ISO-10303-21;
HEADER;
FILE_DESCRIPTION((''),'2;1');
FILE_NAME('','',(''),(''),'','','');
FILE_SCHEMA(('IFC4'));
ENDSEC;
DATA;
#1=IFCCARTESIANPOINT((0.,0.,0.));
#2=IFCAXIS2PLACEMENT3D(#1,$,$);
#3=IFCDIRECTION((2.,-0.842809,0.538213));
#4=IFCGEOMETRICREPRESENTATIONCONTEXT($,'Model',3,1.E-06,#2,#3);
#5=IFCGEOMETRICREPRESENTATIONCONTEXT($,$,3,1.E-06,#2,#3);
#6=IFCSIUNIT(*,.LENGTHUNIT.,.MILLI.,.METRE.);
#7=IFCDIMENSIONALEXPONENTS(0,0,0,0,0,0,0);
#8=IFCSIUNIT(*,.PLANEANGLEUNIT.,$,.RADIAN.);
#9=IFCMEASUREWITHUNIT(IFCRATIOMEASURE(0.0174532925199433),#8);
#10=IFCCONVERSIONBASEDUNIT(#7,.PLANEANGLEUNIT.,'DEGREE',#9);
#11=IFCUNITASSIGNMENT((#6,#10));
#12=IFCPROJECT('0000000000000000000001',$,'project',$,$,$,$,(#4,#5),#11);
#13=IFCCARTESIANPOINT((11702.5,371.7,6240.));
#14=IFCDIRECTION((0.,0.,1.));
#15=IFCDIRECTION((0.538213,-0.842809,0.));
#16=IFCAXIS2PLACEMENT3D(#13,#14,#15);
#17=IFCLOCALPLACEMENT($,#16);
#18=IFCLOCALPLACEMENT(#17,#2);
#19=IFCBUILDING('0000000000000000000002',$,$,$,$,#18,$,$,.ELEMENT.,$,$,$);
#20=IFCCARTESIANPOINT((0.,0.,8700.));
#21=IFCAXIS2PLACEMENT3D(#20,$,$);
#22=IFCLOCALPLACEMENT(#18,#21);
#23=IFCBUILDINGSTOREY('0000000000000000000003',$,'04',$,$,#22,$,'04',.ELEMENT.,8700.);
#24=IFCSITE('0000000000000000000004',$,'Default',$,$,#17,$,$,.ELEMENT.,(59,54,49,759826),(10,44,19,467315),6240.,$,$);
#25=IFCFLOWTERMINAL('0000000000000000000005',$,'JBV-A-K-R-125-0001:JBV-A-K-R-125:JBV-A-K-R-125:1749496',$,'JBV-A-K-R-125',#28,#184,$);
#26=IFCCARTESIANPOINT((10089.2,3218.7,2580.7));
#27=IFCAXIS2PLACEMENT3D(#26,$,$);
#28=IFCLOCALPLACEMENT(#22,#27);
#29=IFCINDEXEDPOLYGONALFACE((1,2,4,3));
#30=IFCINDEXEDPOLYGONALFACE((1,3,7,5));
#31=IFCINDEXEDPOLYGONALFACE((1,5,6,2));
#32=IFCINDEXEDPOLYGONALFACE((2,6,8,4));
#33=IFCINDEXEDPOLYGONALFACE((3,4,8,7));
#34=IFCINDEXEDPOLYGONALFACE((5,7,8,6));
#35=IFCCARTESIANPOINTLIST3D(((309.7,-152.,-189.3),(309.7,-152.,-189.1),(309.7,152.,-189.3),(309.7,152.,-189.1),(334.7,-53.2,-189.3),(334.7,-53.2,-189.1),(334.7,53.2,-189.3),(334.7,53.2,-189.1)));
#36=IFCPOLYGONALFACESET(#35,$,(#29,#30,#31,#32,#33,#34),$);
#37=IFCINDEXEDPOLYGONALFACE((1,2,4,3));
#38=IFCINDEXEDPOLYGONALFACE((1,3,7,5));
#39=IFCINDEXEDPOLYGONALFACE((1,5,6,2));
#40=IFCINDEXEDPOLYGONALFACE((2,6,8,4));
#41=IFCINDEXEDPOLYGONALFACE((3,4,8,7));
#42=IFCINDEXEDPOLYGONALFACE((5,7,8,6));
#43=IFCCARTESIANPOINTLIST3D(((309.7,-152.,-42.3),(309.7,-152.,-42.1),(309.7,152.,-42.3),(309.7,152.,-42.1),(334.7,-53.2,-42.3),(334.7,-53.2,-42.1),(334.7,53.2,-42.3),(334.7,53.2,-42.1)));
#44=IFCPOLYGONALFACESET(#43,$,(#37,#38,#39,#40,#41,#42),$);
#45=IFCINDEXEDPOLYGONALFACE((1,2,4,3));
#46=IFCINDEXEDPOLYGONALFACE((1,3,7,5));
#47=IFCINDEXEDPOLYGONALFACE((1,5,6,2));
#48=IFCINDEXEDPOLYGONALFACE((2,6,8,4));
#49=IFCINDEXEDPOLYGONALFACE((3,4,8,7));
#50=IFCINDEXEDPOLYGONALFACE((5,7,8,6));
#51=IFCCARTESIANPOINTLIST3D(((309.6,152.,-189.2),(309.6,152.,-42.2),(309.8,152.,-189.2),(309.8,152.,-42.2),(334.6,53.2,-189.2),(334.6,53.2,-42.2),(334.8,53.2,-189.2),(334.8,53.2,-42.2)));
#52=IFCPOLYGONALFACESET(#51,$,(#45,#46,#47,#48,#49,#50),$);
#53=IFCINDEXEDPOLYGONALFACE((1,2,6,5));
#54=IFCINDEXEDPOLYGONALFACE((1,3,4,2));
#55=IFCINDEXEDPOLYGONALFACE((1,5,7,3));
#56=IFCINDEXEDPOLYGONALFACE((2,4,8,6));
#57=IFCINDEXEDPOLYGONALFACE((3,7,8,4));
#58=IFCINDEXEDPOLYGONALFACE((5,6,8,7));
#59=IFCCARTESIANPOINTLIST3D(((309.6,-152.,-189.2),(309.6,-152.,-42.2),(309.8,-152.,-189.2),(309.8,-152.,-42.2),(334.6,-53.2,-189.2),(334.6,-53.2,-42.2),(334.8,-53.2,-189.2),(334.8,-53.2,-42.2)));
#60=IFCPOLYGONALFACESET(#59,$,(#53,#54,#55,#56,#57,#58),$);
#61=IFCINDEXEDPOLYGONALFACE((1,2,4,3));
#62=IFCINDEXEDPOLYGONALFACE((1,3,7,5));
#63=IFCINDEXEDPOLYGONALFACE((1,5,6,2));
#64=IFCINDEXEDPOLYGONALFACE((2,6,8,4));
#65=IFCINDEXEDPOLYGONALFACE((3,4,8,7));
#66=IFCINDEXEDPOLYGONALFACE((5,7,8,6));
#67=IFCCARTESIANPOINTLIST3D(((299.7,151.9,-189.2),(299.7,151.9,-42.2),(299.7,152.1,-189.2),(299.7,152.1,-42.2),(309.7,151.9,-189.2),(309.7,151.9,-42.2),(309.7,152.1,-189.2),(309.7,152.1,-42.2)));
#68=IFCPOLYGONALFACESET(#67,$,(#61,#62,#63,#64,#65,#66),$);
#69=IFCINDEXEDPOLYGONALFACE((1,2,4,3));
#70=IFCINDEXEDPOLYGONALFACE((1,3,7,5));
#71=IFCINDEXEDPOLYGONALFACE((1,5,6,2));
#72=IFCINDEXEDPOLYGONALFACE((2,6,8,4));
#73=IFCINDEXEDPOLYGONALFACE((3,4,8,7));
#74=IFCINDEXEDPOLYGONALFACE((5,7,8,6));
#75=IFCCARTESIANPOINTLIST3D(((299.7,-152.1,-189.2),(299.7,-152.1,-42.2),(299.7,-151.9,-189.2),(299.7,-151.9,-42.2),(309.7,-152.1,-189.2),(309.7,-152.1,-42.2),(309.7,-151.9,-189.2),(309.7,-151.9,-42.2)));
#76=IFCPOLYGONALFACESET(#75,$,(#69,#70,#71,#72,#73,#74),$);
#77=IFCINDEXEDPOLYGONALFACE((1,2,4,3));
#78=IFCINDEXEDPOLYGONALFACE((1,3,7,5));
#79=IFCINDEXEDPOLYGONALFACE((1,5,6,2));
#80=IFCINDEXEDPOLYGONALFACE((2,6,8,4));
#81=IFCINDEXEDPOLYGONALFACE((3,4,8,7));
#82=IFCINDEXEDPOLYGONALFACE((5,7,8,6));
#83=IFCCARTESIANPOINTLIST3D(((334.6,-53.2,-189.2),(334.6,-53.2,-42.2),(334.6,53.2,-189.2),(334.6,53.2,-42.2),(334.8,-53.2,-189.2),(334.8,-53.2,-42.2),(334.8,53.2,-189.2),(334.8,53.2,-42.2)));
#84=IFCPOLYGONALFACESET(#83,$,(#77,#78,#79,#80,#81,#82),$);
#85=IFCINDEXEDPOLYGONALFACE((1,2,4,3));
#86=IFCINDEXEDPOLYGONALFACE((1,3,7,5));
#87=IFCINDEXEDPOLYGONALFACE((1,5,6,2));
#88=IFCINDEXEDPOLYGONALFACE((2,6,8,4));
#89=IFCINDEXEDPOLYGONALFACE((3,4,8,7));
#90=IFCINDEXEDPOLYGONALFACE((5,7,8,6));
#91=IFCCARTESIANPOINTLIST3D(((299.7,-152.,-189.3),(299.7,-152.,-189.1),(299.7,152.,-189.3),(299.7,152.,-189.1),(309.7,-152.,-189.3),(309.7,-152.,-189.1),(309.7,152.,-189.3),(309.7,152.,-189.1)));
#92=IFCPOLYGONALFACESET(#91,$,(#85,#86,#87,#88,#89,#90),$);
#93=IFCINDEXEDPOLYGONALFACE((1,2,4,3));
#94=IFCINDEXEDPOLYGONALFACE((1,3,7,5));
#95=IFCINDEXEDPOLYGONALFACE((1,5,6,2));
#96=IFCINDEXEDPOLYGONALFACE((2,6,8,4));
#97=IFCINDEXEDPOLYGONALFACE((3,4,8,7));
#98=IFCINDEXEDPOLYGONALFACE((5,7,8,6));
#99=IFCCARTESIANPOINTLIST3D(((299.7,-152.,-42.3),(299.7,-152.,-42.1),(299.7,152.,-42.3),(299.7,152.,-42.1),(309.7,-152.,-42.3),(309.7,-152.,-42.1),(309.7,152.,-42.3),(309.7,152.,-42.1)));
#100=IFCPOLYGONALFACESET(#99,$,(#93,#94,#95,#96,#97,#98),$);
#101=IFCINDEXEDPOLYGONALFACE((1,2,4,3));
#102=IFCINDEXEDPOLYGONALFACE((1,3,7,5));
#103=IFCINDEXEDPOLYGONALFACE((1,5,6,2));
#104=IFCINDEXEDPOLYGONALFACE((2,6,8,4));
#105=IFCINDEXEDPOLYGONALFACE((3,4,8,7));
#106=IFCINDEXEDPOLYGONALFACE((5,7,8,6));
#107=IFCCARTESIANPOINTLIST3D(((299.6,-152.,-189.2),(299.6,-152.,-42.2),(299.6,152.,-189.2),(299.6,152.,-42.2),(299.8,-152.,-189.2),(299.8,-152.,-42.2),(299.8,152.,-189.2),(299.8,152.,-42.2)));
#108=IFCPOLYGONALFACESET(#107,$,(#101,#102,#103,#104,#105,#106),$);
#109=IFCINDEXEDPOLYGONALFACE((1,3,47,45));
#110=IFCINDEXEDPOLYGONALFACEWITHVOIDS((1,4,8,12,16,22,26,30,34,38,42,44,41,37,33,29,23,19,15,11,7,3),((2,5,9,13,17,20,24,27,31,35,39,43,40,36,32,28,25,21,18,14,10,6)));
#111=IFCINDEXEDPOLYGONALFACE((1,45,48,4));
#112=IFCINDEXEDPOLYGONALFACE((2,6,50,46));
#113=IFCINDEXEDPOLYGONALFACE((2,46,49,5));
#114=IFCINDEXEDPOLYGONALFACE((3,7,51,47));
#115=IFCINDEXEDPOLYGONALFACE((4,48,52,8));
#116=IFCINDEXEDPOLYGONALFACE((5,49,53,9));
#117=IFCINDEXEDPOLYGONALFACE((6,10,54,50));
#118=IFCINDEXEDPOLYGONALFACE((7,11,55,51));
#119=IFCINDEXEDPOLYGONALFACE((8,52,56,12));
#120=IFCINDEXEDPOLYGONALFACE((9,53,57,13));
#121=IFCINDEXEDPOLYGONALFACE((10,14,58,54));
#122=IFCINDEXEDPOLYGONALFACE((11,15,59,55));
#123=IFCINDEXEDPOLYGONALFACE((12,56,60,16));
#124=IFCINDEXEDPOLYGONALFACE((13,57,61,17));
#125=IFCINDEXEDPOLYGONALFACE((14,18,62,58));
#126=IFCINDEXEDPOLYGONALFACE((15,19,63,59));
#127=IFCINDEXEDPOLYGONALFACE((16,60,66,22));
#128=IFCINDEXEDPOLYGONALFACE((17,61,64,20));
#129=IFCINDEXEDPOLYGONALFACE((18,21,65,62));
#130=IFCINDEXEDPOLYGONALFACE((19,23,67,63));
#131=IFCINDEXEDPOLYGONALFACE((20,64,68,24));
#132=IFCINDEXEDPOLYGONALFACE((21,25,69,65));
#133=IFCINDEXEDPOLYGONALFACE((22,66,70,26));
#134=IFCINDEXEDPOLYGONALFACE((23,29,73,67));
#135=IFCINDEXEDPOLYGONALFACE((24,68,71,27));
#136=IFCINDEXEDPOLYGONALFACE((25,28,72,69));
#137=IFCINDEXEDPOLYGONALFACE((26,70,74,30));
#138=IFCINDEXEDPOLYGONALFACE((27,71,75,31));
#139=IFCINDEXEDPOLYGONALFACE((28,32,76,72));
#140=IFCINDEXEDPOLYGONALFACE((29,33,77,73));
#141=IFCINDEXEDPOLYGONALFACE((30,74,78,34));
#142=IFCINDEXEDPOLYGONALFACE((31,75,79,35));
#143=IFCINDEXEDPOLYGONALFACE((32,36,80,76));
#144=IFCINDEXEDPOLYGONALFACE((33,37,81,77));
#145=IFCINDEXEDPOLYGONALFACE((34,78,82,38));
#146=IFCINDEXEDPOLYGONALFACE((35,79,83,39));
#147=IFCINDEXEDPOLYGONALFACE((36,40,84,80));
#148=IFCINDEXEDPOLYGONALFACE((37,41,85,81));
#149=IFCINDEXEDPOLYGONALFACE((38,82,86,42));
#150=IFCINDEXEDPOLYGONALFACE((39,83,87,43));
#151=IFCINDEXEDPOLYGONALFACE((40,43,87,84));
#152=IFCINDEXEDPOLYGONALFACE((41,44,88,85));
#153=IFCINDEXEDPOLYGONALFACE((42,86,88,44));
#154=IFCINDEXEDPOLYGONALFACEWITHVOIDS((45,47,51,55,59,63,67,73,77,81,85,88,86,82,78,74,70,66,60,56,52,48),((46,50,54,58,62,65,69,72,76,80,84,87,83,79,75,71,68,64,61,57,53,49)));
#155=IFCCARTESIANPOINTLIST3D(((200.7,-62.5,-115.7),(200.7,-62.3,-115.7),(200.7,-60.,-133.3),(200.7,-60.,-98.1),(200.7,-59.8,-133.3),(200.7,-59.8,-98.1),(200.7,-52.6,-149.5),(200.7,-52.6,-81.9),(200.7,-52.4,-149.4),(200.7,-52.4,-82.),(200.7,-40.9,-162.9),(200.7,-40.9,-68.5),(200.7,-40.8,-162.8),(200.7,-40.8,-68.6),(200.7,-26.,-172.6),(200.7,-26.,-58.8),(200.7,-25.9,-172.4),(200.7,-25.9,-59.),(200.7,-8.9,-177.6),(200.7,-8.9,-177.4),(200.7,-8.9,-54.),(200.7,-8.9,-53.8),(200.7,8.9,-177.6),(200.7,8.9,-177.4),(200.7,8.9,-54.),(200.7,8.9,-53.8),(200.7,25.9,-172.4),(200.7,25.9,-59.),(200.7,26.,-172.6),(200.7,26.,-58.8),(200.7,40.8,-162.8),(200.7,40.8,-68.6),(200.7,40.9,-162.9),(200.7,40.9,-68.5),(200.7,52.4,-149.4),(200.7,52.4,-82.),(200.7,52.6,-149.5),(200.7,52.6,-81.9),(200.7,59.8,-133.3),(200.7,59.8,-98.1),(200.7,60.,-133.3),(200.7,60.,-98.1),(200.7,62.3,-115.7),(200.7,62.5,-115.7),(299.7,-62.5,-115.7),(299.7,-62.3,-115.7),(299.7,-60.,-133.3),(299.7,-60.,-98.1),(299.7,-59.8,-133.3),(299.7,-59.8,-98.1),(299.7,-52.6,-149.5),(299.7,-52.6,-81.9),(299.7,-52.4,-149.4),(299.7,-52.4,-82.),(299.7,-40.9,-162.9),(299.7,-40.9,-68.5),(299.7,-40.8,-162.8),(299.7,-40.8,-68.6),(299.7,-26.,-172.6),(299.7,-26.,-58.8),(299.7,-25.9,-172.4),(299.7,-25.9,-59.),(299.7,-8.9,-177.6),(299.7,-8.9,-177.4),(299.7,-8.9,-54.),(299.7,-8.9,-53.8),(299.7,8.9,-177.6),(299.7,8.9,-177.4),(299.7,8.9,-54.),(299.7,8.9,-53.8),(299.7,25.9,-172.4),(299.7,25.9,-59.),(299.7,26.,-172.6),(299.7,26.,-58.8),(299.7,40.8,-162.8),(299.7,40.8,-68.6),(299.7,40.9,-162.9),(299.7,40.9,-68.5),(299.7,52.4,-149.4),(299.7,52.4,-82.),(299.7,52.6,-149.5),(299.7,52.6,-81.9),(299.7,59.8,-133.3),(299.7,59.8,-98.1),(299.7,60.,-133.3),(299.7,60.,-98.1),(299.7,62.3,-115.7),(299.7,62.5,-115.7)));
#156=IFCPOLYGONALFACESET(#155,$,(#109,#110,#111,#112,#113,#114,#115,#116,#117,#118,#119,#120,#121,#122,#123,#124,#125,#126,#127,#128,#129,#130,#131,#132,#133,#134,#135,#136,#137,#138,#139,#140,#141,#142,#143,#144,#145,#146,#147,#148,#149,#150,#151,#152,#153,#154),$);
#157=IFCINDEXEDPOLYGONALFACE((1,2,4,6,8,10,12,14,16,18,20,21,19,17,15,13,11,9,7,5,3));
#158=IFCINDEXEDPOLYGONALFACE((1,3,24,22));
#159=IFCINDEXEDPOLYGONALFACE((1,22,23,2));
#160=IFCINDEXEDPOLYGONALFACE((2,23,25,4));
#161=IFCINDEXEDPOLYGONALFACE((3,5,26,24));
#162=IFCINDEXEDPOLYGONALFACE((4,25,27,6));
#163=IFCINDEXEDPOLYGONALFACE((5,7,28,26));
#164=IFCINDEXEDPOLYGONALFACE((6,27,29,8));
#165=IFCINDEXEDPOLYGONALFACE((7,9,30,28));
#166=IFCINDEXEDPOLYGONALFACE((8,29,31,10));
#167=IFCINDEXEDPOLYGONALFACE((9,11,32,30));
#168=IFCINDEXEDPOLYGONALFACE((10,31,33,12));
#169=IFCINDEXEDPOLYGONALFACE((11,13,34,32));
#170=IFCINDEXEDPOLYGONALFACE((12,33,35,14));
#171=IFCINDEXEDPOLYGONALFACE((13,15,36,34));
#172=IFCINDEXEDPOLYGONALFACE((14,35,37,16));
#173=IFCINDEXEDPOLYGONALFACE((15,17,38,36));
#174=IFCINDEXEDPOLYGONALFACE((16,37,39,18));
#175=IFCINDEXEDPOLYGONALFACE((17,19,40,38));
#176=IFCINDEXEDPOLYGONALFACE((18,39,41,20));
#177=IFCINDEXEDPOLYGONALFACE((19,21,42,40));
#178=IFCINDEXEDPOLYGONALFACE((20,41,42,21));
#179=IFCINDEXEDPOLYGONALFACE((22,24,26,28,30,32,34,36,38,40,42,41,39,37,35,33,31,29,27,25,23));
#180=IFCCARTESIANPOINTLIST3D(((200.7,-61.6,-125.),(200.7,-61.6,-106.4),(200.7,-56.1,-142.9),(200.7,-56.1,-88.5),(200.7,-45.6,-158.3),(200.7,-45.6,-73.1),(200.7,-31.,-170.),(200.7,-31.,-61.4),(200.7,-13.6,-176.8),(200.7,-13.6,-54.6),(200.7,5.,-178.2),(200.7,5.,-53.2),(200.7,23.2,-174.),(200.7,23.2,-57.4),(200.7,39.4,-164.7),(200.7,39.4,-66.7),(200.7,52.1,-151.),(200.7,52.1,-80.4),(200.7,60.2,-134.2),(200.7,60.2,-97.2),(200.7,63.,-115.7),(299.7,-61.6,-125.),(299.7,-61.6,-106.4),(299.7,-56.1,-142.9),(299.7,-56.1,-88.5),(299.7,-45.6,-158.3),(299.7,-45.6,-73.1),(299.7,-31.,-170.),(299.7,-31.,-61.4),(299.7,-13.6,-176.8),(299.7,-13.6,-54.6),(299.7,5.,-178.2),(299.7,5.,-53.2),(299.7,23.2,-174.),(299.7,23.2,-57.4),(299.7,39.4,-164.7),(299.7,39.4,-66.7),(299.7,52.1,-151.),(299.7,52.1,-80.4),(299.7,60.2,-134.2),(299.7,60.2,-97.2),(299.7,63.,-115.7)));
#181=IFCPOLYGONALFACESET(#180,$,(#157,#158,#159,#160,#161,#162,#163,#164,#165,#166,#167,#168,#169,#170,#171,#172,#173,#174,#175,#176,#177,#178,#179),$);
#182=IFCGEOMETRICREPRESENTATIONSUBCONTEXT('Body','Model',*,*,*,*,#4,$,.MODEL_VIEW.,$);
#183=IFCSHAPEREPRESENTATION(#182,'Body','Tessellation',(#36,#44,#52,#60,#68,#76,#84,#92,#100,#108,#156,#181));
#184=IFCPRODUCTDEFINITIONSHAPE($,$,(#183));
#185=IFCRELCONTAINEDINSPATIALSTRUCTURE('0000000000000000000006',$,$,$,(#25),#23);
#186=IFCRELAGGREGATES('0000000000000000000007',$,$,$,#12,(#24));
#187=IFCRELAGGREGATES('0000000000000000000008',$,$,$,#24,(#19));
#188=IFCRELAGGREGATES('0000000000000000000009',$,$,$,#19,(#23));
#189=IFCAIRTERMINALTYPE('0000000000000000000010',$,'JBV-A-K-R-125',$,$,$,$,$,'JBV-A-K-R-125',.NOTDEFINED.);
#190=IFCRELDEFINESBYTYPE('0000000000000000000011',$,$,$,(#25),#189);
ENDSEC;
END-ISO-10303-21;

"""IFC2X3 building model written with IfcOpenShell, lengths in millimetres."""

from ifc_helpers import new_model, entity, si_unit, converted_unit, direction, frame, frame_2d, origin, origin_2d_with_axis, place, context, subcontext, project, spatial, polyline, circle_curve, parameter, trimmed, segment, composite_curve, rectangle, circle, outline, extrude, source, transform, mapped, type_object, type_shapes, element, save


model = new_model("IFC2X3")

# Units and contexts
model_context = context("Model", 3, precision=1e-06, world=origin(), true_north=direction((2.0, -0.842809, 0.538213)))
context_of_model = context(None, 3, precision=1e-06, world=origin(), true_north=direction((2.0, -0.842809, 0.538213)))
body_context = subcontext(model_context, "Body", "Model", "MODEL_VIEW")
ifc_project = project(units=[si_unit("LENGTHUNIT", "METRE", prefix="MILLI"), converted_unit("PLANEANGLEUNIT", "DEGREE", entity("IfcRatioMeasure", 0.0174532925199433), si_unit("PLANEANGLEUNIT", "RADIAN"), dimensions=[0, 0, 0, 0, 0, 0, 0])], contexts=[model_context, context_of_model])

# Site, building, storey
site_placement = place(None, frame((11702.5, 371.7, 6240.0), z_axis=(0.0, 0.0, 1.0), x_axis=(0.538213, -0.842809, 0.0)))
site = spatial("IfcSite", under=ifc_project, at=site_placement, Name="Default", CompositionType="ELEMENT", RefLatitude=(59, 54, 49, 759826), RefLongitude=(10, 44, 19, 467315), RefElevation=6240.0)
building_placement = place(site_placement, origin())
building = spatial("IfcBuilding", under=site, at=building_placement, CompositionType="ELEMENT")
storey_placement = place(building_placement, frame((0.0, 0.0, 8700.0)))
storey = spatial("IfcBuildingStorey", under=building, at=storey_placement, Name="04", LongName="04", CompositionType="ELEMENT", Elevation=8700.0)

# Flow terminal
air_terminal_type_1 = type_object("IfcAirTerminalType", Name="JBV-A-K-R-125", ElementType="JBV-A-K-R-125", PredefinedType="NOTDEFINED")
shared_shape_1 = source(origin(), body_context, "Body", "SweptSolid", [
    extrude(outline(polyline([(-152.0, -12.5), (152.0, -12.5), (53.2, 12.5), (-53.2, 12.5), (-152.0, -12.5)])), frame((322.2, 0.0, -189.3), z_axis=(0.0, 0.0, 1.0), x_axis=(0.0, -1.0, 0.0)), (0.0, 0.0, 1.0), 0.2),
    extrude(outline(polyline([(-152.0, -12.5), (152.0, -12.5), (53.2, 12.5), (-53.2, 12.5), (-152.0, -12.5)])), frame((322.2, 0.0, -42.3), z_axis=(0.0, 0.0, 1.0), x_axis=(0.0, -1.0, 0.0)), (0.0, 0.0, 1.0), 0.2),
    extrude(rectangle(XDim=0.2, YDim=101.9, at=frame_2d((0.0, 0.0), x_axis=(1.0, 0.0))), frame((322.2, 102.6, -189.2), z_axis=(0.0, 0.0, 1.0), x_axis=(0.969446, 0.245305, 0.0)), (0.0, 0.0, 1.0), 147.0),
    extrude(rectangle(XDim=0.2, YDim=101.9, at=frame_2d((0.0, 0.0), x_axis=(1.0, 0.0))), frame((322.2, -102.6, -189.2), z_axis=(0.0, 0.0, 1.0), x_axis=(-0.969446, 0.245305, 0.0)), (0.0, 0.0, 1.0), 147.0),
    extrude(rectangle(XDim=0.2, YDim=10.0, at=frame_2d((0.0, 0.0), x_axis=(1.0, 0.0))), frame((304.7, 152.0, -189.2), z_axis=(0.0, 0.0, 1.0), x_axis=(0.0, 1.0, 0.0)), (0.0, 0.0, 1.0), 147.0),
    extrude(rectangle(XDim=0.2, YDim=10.0, at=frame_2d((0.0, 0.0), x_axis=(1.0, 0.0))), frame((304.7, -152.0, -189.2), z_axis=(0.0, 0.0, 1.0), x_axis=(0.0, 1.0, 0.0)), (0.0, 0.0, 1.0), 147.0),
    extrude(rectangle(XDim=0.2, YDim=106.4, at=frame_2d((0.0, 0.0), x_axis=(1.0, 0.0))), frame((334.7, 0.0, -189.2)), (0.0, 0.0, 1.0), 147.0),
    extrude(rectangle(XDim=304.0, YDim=10.0, at=frame_2d((0.0, 0.0), x_axis=(1.0, 0.0))), frame((304.7, 0.0, -189.3), z_axis=(0.0, 0.0, 1.0), x_axis=(0.0, -1.0, 0.0)), (0.0, 0.0, 1.0), 0.2),
    extrude(rectangle(XDim=304.0, YDim=10.0, at=frame_2d((0.0, 0.0), x_axis=(1.0, 0.0))), frame((304.7, 0.0, -42.3), z_axis=(0.0, 0.0, 1.0), x_axis=(0.0, -1.0, 0.0)), (0.0, 0.0, 1.0), 0.2),
    extrude(rectangle(XDim=0.2, YDim=304.0, at=frame_2d((0.0, 0.0), x_axis=(1.0, 0.0))), frame((299.7, 0.0, -189.2)), (0.0, 0.0, 1.0), 147.0),
    extrude(outline(composite_curve([segment(trimmed(circle_curve(origin_2d_with_axis(), 62.5), [parameter(0.0)], [parameter(180.0)], True, "PARAMETER"), True, "CONTINUOUS"), segment(trimmed(circle_curve(origin_2d_with_axis(), 62.5), [parameter(180.0)], [parameter(360.0)], True, "PARAMETER"), True, "CONTINUOUS")], self_intersect=False), holes=[composite_curve([segment(trimmed(circle_curve(origin_2d_with_axis(), 62.3), [parameter(180.0)], [parameter(360.0)], True, "PARAMETER"), False, "CONTINUOUS"), segment(trimmed(circle_curve(origin_2d_with_axis(), 62.3), [parameter(0.0)], [parameter(180.0)], True, "PARAMETER"), False, "CONTINUOUS")], self_intersect=False)]), frame((200.7, 0.0, -115.7), z_axis=(1.0, 0.0, 0.0), x_axis=(0.0, 1.0, 0.0)), (0.0, 0.0, 1.0), 99.0),
    extrude(circle(Radius=62.6, at=frame_2d((0.0, 0.0), x_axis=(1.0, 0.0))), frame((200.7, 0.3, -115.7), z_axis=(1.0, 0.0, 0.0), x_axis=(0.0, 1.0, 0.0)), (0.0, 0.0, 1.0), 99.0),
])
type_shapes(air_terminal_type_1, [shared_shape_1])
for number, where, name in (
    (1, (10089.2, 3218.7, 2580.7), "JBV-A-K-R-125-0001:JBV-A-K-R-125:JBV-A-K-R-125:1749496"),
):
    element("IfcFlowTerminal", number, at=place(storey_placement, frame(where)), inside=storey, type_object=air_terminal_type_1, Name=name, ObjectType="JBV-A-K-R-125", context=body_context, shape_type="MappedRepresentation", body=[
        mapped(shared_shape_1, transform((0.0, 0.0, 0.0), scale=1.0)),
    ])

save(model, "model.ifc")
